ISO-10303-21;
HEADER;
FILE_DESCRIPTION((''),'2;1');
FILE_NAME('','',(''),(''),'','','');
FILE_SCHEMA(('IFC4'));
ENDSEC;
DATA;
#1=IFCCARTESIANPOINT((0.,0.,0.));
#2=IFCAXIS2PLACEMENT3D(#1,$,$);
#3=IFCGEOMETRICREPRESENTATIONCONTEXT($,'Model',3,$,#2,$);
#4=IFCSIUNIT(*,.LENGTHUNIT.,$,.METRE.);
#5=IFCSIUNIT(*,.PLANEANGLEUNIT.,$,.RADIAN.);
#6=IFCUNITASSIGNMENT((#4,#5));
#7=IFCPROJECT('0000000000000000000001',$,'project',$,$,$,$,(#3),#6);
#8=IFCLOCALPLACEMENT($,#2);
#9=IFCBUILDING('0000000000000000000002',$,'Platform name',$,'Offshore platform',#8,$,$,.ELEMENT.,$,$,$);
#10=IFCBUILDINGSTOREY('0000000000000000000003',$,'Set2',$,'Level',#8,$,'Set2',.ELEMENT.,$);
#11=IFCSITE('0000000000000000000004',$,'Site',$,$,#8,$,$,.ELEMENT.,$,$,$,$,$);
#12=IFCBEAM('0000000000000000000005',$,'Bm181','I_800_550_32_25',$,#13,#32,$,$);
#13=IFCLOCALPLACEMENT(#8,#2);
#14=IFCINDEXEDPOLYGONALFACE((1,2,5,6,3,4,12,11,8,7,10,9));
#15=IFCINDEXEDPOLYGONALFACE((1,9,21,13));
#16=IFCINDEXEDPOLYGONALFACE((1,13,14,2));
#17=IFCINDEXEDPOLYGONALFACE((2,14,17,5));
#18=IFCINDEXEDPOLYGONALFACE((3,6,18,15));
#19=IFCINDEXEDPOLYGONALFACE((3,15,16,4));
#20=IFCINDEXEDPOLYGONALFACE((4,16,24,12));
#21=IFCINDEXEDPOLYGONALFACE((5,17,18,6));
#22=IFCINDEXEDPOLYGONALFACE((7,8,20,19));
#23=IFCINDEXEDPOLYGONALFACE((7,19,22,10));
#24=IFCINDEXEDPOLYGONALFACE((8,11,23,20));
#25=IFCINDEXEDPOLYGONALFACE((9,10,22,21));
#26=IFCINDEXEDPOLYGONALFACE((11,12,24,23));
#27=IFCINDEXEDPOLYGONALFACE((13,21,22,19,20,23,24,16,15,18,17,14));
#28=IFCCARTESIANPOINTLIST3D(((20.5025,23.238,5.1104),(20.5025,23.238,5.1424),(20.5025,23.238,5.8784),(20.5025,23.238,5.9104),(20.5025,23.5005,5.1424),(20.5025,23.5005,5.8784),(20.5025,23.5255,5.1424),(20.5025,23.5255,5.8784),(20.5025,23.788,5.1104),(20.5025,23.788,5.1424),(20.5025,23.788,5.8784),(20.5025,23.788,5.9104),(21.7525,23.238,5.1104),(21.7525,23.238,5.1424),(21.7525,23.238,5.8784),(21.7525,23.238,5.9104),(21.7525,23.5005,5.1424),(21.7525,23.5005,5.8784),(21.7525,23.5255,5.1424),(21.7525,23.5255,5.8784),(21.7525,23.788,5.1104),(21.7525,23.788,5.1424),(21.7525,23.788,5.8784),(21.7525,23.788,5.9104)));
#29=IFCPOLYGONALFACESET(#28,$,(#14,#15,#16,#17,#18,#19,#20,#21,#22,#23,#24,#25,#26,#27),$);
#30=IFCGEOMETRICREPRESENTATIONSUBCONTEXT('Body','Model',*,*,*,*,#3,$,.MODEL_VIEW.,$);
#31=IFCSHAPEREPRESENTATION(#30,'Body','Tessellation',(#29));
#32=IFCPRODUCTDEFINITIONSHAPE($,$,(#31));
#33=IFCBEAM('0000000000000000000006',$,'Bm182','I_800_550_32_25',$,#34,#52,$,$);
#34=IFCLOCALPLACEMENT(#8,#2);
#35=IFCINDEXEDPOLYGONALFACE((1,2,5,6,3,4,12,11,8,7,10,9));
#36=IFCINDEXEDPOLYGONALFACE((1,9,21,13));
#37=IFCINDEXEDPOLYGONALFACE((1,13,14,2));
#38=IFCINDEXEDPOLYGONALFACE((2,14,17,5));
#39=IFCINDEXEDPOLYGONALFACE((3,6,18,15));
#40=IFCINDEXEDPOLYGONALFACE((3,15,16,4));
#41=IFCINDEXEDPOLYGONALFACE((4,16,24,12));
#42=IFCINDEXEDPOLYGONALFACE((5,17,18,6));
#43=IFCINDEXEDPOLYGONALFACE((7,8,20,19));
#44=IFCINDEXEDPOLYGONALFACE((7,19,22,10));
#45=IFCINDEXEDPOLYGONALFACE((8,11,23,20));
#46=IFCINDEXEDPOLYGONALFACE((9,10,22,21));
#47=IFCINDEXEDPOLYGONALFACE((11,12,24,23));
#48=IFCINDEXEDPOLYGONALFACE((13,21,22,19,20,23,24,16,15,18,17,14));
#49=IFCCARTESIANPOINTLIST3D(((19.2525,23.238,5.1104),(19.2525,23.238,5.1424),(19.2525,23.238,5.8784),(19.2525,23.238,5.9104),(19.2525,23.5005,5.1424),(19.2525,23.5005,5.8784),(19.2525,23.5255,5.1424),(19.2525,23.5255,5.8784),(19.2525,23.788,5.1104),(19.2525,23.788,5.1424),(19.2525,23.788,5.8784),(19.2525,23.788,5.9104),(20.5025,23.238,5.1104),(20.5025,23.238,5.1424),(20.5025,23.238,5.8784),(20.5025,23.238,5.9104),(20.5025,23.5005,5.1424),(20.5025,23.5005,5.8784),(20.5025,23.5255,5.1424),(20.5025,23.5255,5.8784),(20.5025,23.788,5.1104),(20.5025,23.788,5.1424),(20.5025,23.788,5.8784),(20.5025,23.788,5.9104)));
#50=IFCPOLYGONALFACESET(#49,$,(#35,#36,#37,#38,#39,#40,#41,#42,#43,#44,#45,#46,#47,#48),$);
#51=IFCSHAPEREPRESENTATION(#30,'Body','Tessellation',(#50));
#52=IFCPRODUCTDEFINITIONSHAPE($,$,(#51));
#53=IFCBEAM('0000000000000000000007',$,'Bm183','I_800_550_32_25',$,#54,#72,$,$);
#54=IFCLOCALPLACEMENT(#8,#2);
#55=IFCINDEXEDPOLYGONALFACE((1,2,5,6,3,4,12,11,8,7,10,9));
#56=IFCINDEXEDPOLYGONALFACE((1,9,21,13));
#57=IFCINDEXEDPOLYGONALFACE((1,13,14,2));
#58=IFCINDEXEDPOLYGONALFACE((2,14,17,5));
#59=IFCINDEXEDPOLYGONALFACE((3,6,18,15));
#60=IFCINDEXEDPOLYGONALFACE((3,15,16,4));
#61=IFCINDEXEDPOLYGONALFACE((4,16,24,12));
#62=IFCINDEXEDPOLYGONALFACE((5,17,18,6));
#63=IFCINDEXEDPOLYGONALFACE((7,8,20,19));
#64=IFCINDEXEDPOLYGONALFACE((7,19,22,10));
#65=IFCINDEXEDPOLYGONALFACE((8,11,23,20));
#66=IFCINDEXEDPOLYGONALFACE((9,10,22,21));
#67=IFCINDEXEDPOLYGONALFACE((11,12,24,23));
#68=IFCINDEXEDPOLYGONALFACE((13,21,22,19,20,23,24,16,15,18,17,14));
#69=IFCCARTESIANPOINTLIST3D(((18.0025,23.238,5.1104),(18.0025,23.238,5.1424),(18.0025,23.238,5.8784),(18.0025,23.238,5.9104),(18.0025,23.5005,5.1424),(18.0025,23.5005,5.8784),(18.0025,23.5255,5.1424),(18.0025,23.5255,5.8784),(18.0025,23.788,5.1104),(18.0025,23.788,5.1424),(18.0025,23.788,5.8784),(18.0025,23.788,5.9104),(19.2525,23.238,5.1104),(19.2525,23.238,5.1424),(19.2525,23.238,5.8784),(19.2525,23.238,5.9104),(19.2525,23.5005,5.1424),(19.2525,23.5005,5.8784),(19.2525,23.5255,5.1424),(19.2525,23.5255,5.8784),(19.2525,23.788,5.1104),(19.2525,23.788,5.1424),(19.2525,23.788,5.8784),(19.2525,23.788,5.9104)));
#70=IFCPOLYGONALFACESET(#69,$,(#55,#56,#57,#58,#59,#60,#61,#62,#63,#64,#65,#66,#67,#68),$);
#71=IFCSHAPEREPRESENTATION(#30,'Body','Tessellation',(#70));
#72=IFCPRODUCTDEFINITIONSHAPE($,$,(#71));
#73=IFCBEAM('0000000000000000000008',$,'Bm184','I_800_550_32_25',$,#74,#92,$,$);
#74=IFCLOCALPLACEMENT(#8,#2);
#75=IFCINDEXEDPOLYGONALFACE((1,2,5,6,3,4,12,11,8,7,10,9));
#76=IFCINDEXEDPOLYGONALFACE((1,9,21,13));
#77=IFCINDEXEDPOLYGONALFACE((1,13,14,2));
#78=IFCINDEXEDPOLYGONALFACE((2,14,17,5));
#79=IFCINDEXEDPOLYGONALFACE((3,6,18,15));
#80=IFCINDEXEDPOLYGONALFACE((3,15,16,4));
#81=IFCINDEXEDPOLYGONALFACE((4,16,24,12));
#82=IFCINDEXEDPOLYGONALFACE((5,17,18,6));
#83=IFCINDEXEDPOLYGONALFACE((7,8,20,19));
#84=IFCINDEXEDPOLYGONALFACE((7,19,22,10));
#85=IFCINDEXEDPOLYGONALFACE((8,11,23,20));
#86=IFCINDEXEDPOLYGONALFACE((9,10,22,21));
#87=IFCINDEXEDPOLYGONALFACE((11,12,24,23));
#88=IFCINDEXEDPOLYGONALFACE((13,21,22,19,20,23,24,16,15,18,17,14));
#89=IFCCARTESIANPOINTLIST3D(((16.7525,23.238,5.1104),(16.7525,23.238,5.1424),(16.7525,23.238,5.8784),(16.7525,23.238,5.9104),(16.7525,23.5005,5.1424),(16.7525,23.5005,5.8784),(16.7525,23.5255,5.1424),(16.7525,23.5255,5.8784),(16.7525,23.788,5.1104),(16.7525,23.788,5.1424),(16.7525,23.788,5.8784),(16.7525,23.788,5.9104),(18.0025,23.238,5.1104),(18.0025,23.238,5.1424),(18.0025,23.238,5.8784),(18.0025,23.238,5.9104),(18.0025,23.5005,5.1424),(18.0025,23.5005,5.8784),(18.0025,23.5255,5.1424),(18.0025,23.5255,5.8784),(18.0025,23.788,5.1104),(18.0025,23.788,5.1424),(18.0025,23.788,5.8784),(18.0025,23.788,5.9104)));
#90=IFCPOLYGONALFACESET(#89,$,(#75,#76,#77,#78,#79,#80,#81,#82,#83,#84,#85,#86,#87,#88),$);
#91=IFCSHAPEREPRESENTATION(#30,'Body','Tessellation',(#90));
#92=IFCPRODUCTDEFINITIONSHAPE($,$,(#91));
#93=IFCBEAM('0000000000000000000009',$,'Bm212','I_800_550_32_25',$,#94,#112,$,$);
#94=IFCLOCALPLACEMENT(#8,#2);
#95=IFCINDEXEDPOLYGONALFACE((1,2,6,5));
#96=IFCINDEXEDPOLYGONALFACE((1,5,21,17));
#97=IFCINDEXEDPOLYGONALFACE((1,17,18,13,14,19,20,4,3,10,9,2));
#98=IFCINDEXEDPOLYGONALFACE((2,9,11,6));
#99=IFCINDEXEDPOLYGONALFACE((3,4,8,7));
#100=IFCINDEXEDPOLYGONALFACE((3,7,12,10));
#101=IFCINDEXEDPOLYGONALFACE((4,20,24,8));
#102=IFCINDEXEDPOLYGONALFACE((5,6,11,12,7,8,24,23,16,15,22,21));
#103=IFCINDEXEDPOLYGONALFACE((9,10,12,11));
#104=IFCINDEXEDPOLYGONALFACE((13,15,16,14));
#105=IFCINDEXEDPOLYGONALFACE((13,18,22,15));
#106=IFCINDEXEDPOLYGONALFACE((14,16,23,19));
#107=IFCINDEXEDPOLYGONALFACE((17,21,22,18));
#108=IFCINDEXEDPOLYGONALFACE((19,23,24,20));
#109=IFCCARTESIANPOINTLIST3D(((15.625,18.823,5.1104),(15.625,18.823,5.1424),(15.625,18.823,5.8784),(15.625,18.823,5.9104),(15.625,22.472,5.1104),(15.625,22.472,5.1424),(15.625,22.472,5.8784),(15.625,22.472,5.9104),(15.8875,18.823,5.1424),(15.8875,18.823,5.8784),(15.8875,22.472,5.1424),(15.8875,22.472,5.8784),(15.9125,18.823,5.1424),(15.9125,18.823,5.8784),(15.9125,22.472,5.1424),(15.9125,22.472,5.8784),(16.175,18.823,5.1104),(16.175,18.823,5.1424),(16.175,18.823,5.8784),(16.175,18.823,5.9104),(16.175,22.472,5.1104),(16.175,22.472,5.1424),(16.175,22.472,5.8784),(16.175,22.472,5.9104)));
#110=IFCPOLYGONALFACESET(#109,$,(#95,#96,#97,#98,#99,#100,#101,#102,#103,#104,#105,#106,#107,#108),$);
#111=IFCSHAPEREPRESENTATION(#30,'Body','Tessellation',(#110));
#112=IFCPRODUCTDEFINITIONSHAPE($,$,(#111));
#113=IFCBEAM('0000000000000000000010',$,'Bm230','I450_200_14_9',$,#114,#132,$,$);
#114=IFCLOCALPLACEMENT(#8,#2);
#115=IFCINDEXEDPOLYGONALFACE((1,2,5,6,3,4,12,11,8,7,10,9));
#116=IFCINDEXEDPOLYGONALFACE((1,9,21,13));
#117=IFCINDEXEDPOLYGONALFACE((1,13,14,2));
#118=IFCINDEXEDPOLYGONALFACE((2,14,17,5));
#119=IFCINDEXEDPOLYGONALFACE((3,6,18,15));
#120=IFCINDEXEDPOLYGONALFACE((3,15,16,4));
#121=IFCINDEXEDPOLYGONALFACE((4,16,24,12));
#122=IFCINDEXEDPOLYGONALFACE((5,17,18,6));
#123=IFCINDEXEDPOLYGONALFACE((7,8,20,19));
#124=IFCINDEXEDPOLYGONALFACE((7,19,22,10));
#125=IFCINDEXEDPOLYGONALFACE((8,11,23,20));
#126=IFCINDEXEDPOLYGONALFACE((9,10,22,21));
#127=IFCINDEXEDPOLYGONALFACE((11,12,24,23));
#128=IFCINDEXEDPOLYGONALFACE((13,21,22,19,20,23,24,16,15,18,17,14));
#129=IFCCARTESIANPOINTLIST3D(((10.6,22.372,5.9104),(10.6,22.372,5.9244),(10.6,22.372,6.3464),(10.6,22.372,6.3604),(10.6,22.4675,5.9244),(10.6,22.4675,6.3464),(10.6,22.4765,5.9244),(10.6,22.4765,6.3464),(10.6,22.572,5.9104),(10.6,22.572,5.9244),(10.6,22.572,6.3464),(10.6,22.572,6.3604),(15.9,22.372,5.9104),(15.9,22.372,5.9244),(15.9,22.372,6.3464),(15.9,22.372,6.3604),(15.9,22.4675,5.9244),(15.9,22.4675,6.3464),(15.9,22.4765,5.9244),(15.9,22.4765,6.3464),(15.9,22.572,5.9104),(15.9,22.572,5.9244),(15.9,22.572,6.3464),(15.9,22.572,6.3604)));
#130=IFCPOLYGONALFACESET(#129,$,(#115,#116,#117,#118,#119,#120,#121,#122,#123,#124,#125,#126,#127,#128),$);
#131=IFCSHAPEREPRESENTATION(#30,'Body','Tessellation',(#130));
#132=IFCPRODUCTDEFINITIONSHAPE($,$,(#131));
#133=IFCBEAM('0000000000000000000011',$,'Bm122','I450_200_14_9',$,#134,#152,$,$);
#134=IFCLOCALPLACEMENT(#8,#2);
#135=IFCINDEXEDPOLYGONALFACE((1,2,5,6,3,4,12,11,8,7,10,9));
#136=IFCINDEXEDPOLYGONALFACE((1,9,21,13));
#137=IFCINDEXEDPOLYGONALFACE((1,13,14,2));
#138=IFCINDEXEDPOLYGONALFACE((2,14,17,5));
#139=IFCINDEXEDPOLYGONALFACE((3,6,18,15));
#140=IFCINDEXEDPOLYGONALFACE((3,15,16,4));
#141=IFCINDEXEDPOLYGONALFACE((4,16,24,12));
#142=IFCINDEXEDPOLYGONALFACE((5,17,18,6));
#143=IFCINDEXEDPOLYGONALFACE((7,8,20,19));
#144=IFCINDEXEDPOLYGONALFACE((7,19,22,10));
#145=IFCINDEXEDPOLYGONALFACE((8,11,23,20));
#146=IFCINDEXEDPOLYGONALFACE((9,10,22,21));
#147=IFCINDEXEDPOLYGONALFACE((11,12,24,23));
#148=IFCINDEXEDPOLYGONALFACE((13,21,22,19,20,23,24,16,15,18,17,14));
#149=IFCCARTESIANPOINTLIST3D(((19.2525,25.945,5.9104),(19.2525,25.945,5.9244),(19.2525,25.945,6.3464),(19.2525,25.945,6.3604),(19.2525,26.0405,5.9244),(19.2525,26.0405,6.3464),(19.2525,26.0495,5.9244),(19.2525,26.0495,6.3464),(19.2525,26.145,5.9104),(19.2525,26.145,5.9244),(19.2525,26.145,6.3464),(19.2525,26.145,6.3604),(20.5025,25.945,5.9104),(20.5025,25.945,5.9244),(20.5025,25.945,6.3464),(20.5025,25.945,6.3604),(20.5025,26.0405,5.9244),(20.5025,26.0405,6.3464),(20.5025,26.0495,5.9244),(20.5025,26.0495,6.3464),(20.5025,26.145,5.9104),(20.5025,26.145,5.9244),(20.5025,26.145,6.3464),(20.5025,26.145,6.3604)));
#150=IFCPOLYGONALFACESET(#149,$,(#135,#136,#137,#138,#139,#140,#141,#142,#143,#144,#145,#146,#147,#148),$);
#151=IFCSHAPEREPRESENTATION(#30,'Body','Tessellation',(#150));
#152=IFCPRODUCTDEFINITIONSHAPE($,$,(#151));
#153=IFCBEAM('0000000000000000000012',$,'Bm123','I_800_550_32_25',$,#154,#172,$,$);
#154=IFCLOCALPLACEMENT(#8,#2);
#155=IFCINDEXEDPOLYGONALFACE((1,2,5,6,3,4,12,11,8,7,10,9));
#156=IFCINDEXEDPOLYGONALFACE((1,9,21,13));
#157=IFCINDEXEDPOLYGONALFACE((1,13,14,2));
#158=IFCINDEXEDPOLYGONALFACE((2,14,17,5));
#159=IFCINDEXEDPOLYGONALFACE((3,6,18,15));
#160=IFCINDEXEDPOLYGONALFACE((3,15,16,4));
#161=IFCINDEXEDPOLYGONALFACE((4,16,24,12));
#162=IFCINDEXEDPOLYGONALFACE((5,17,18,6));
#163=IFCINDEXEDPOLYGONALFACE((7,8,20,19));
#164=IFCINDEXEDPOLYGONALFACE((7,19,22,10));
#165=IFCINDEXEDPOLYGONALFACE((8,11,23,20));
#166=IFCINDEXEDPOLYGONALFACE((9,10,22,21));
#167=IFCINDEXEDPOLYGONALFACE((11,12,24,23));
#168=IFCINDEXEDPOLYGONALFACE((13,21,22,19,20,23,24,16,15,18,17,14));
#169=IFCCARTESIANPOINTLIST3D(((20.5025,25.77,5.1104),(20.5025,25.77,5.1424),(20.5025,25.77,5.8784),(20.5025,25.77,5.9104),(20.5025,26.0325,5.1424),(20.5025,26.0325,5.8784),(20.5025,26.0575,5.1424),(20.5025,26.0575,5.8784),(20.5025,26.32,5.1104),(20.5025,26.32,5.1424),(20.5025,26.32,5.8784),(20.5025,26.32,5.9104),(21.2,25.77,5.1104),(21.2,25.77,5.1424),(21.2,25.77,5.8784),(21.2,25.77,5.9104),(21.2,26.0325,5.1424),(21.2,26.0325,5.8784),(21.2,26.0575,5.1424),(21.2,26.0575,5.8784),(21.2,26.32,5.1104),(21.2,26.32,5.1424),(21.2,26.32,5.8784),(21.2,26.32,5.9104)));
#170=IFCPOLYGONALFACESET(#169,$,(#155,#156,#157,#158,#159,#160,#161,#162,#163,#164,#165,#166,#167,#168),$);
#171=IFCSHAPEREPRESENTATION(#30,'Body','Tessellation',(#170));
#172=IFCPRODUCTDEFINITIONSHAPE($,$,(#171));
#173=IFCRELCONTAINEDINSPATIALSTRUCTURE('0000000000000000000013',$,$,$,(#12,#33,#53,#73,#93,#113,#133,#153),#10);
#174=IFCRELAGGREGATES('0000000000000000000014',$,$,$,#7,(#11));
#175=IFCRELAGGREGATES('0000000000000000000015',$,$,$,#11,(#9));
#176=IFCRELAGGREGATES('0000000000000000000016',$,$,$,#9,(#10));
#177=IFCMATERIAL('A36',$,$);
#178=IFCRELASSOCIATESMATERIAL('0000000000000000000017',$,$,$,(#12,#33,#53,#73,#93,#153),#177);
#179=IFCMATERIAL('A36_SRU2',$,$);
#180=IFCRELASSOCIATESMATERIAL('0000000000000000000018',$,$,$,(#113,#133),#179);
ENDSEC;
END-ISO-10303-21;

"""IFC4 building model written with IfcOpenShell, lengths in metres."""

from ifc_helpers import new_model, si_unit, frame, origin, origin_2d, place, context, subcontext, project, spatial, i_section, extrude, source, transform, mapped, material, element, save


model = new_model("IFC4")

# Units and contexts
model_context = context("Model", 3, world=origin())
body_context = subcontext(model_context, "Body", "Model", "MODEL_VIEW")
ifc_project = project(units=[si_unit("LENGTHUNIT", "METRE"), si_unit("PLANEANGLEUNIT", "RADIAN")], contexts=[model_context])

# Site, building, storey
placement_1 = place(None, origin())
site = spatial("IfcSite", under=ifc_project, at=placement_1, Name="Site", CompositionType="ELEMENT")
building = spatial("IfcBuilding", under=site, at=placement_1, Name="Platform name", ObjectType="Offshore platform", CompositionType="ELEMENT")
storey = spatial("IfcBuildingStorey", under=building, at=placement_1, Name="Set2", ObjectType="Level", LongName="Set2", CompositionType="ELEMENT")

# Beams
ifc_material_1 = material(Name="A36_SRU2")
ifc_material_2 = material(Name="A36")
shared_shape_1 = source(origin(), body_context, "Body", "SweptSolid", [
    extrude(i_section(OverallWidth=0.55, OverallDepth=0.8, WebThickness=0.025, FlangeThickness=0.032, FilletRadius=0.0, at=origin_2d()), frame((0.0, 0.0, 0.0), z_axis=(1.0, 0.0, 0.0), x_axis=(0.0, 1.0, 0.0)), (0.0, 0.0, 1.0), 1.25),
])
placement_2 = place(None, origin())
placement_3 = place(placement_2, origin())
placement_4 = place(placement_3, origin())
beam_1_placement = place(placement_4, frame((20.5025, 23.513, 5.5104)))
element("IfcBeam", 1, at=beam_1_placement, inside=storey, material=ifc_material_2, Name="Bm181", Description="I_800_550_32_25", context=body_context, shape_type="MappedRepresentation", body=[
    mapped(shared_shape_1, transform((0.0, 0.0, 0.0), scale=1.0)),
])
shared_shape_2 = source(origin(), body_context, "Body", "SweptSolid", [
    extrude(i_section(OverallWidth=0.55, OverallDepth=0.8, WebThickness=0.025, FlangeThickness=0.032, FilletRadius=0.0, at=origin_2d()), frame((0.0, 0.0, 0.0), z_axis=(1.0, 0.0, 0.0), x_axis=(0.0, 1.0, 0.0)), (0.0, 0.0, 1.0), 1.25),
])
placement_5 = place(None, origin())
placement_6 = place(placement_5, origin())
placement_7 = place(placement_6, origin())
beam_2_placement = place(placement_7, frame((19.2525, 23.513, 5.5104)))
element("IfcBeam", 2, at=beam_2_placement, inside=storey, material=ifc_material_2, Name="Bm182", Description="I_800_550_32_25", context=body_context, shape_type="MappedRepresentation", body=[
    mapped(shared_shape_2, transform((0.0, 0.0, 0.0), scale=1.0)),
])
shared_shape_3 = source(origin(), body_context, "Body", "SweptSolid", [
    extrude(i_section(OverallWidth=0.55, OverallDepth=0.8, WebThickness=0.025, FlangeThickness=0.032, FilletRadius=0.0, at=origin_2d()), frame((0.0, 0.0, 0.0), z_axis=(1.0, 0.0, 0.0), x_axis=(0.0, 1.0, 0.0)), (0.0, 0.0, 1.0), 1.25),
])
placement_8 = place(None, origin())
placement_9 = place(placement_8, origin())
placement_10 = place(placement_9, origin())
beam_3_placement = place(placement_10, frame((18.0025, 23.513, 5.5104)))
element("IfcBeam", 3, at=beam_3_placement, inside=storey, material=ifc_material_2, Name="Bm183", Description="I_800_550_32_25", context=body_context, shape_type="MappedRepresentation", body=[
    mapped(shared_shape_3, transform((0.0, 0.0, 0.0), scale=1.0)),
])
shared_shape_4 = source(origin(), body_context, "Body", "SweptSolid", [
    extrude(i_section(OverallWidth=0.55, OverallDepth=0.8, WebThickness=0.025, FlangeThickness=0.032, FilletRadius=0.0, at=origin_2d()), frame((0.0, 0.0, 0.0), z_axis=(1.0, 0.0, 0.0), x_axis=(0.0, 1.0, 0.0)), (0.0, 0.0, 1.0), 1.25),
])
placement_11 = place(None, origin())
placement_12 = place(placement_11, origin())
placement_13 = place(placement_12, origin())
beam_4_placement = place(placement_13, frame((16.7525, 23.513, 5.5104)))
element("IfcBeam", 4, at=beam_4_placement, inside=storey, material=ifc_material_2, Name="Bm184", Description="I_800_550_32_25", context=body_context, shape_type="MappedRepresentation", body=[
    mapped(shared_shape_4, transform((0.0, 0.0, 0.0), scale=1.0)),
])
shared_shape_5 = source(origin(), body_context, "Body", "SweptSolid", [
    extrude(i_section(OverallWidth=0.55, OverallDepth=0.8, WebThickness=0.025, FlangeThickness=0.032, FilletRadius=0.0, at=origin_2d()), frame((0.0, 0.0, 0.0), z_axis=(0.0, -1.0, 0.0), x_axis=(1.0, 0.0, 0.0)), (0.0, 0.0, 1.0), 3.649),
])
placement_14 = place(None, origin())
placement_15 = place(placement_14, origin())
placement_16 = place(placement_15, origin())
beam_5_placement = place(placement_16, frame((15.9, 22.472, 5.5104)))
element("IfcBeam", 5, at=beam_5_placement, inside=storey, material=ifc_material_2, Name="Bm212", Description="I_800_550_32_25", context=body_context, shape_type="MappedRepresentation", body=[
    mapped(shared_shape_5, transform((0.0, 0.0, 0.0), scale=1.0)),
])
shared_shape_6 = source(origin(), body_context, "Body", "SweptSolid", [
    extrude(i_section(OverallWidth=0.2, OverallDepth=0.45, WebThickness=0.009, FlangeThickness=0.014, FilletRadius=0.0, at=origin_2d()), frame((0.0, 0.0, 0.0), z_axis=(-1.0, 0.0, 0.0), x_axis=(0.0, -1.0, 0.0)), (0.0, 0.0, 1.0), 5.3),
])
placement_17 = place(None, origin())
placement_18 = place(placement_17, origin())
placement_19 = place(placement_18, origin())
beam_6_placement = place(placement_19, frame((15.9, 22.472, 6.1354)))
element("IfcBeam", 6, at=beam_6_placement, inside=storey, material=ifc_material_1, Name="Bm230", Description="I450_200_14_9", context=body_context, shape_type="MappedRepresentation", body=[
    mapped(shared_shape_6, transform((0.0, 0.0, 0.0), scale=1.0)),
])
shared_shape_7 = source(origin(), body_context, "Body", "SweptSolid", [
    extrude(i_section(OverallWidth=0.2, OverallDepth=0.45, WebThickness=0.009, FlangeThickness=0.014, FilletRadius=0.0, at=origin_2d()), frame((0.0, 0.0, 0.0), z_axis=(-1.0, 0.0, 0.0), x_axis=(0.0, -1.0, 0.0)), (0.0, 0.0, 1.0), 1.25),
])
placement_20 = place(None, origin())
placement_21 = place(placement_20, origin())
placement_22 = place(placement_21, origin())
beam_7_placement = place(placement_22, frame((20.5025, 26.045, 6.1354)))
element("IfcBeam", 7, at=beam_7_placement, inside=storey, material=ifc_material_1, Name="Bm122", Description="I450_200_14_9", context=body_context, shape_type="MappedRepresentation", body=[
    mapped(shared_shape_7, transform((0.0, 0.0, 0.0), scale=1.0)),
])
shared_shape_8 = source(origin(), body_context, "Body", "SweptSolid", [
    extrude(i_section(OverallWidth=0.55, OverallDepth=0.8, WebThickness=0.025, FlangeThickness=0.032, FilletRadius=0.0, at=origin_2d()), frame((0.0, 0.0, 0.0), z_axis=(1.0, 0.0, 0.0), x_axis=(0.0, 1.0, 0.0)), (0.0, 0.0, 1.0), 0.6975),
])
placement_23 = place(None, origin())
placement_24 = place(placement_23, origin())
placement_25 = place(placement_24, origin())
beam_8_placement = place(placement_25, frame((20.5025, 26.045, 5.5104)))
element("IfcBeam", 8, at=beam_8_placement, inside=storey, material=ifc_material_2, Name="Bm123", Description="I_800_550_32_25", context=body_context, shape_type="MappedRepresentation", body=[
    mapped(shared_shape_8, transform((0.0, 0.0, 0.0), scale=1.0)),
])

save(model, "model.ifc")
